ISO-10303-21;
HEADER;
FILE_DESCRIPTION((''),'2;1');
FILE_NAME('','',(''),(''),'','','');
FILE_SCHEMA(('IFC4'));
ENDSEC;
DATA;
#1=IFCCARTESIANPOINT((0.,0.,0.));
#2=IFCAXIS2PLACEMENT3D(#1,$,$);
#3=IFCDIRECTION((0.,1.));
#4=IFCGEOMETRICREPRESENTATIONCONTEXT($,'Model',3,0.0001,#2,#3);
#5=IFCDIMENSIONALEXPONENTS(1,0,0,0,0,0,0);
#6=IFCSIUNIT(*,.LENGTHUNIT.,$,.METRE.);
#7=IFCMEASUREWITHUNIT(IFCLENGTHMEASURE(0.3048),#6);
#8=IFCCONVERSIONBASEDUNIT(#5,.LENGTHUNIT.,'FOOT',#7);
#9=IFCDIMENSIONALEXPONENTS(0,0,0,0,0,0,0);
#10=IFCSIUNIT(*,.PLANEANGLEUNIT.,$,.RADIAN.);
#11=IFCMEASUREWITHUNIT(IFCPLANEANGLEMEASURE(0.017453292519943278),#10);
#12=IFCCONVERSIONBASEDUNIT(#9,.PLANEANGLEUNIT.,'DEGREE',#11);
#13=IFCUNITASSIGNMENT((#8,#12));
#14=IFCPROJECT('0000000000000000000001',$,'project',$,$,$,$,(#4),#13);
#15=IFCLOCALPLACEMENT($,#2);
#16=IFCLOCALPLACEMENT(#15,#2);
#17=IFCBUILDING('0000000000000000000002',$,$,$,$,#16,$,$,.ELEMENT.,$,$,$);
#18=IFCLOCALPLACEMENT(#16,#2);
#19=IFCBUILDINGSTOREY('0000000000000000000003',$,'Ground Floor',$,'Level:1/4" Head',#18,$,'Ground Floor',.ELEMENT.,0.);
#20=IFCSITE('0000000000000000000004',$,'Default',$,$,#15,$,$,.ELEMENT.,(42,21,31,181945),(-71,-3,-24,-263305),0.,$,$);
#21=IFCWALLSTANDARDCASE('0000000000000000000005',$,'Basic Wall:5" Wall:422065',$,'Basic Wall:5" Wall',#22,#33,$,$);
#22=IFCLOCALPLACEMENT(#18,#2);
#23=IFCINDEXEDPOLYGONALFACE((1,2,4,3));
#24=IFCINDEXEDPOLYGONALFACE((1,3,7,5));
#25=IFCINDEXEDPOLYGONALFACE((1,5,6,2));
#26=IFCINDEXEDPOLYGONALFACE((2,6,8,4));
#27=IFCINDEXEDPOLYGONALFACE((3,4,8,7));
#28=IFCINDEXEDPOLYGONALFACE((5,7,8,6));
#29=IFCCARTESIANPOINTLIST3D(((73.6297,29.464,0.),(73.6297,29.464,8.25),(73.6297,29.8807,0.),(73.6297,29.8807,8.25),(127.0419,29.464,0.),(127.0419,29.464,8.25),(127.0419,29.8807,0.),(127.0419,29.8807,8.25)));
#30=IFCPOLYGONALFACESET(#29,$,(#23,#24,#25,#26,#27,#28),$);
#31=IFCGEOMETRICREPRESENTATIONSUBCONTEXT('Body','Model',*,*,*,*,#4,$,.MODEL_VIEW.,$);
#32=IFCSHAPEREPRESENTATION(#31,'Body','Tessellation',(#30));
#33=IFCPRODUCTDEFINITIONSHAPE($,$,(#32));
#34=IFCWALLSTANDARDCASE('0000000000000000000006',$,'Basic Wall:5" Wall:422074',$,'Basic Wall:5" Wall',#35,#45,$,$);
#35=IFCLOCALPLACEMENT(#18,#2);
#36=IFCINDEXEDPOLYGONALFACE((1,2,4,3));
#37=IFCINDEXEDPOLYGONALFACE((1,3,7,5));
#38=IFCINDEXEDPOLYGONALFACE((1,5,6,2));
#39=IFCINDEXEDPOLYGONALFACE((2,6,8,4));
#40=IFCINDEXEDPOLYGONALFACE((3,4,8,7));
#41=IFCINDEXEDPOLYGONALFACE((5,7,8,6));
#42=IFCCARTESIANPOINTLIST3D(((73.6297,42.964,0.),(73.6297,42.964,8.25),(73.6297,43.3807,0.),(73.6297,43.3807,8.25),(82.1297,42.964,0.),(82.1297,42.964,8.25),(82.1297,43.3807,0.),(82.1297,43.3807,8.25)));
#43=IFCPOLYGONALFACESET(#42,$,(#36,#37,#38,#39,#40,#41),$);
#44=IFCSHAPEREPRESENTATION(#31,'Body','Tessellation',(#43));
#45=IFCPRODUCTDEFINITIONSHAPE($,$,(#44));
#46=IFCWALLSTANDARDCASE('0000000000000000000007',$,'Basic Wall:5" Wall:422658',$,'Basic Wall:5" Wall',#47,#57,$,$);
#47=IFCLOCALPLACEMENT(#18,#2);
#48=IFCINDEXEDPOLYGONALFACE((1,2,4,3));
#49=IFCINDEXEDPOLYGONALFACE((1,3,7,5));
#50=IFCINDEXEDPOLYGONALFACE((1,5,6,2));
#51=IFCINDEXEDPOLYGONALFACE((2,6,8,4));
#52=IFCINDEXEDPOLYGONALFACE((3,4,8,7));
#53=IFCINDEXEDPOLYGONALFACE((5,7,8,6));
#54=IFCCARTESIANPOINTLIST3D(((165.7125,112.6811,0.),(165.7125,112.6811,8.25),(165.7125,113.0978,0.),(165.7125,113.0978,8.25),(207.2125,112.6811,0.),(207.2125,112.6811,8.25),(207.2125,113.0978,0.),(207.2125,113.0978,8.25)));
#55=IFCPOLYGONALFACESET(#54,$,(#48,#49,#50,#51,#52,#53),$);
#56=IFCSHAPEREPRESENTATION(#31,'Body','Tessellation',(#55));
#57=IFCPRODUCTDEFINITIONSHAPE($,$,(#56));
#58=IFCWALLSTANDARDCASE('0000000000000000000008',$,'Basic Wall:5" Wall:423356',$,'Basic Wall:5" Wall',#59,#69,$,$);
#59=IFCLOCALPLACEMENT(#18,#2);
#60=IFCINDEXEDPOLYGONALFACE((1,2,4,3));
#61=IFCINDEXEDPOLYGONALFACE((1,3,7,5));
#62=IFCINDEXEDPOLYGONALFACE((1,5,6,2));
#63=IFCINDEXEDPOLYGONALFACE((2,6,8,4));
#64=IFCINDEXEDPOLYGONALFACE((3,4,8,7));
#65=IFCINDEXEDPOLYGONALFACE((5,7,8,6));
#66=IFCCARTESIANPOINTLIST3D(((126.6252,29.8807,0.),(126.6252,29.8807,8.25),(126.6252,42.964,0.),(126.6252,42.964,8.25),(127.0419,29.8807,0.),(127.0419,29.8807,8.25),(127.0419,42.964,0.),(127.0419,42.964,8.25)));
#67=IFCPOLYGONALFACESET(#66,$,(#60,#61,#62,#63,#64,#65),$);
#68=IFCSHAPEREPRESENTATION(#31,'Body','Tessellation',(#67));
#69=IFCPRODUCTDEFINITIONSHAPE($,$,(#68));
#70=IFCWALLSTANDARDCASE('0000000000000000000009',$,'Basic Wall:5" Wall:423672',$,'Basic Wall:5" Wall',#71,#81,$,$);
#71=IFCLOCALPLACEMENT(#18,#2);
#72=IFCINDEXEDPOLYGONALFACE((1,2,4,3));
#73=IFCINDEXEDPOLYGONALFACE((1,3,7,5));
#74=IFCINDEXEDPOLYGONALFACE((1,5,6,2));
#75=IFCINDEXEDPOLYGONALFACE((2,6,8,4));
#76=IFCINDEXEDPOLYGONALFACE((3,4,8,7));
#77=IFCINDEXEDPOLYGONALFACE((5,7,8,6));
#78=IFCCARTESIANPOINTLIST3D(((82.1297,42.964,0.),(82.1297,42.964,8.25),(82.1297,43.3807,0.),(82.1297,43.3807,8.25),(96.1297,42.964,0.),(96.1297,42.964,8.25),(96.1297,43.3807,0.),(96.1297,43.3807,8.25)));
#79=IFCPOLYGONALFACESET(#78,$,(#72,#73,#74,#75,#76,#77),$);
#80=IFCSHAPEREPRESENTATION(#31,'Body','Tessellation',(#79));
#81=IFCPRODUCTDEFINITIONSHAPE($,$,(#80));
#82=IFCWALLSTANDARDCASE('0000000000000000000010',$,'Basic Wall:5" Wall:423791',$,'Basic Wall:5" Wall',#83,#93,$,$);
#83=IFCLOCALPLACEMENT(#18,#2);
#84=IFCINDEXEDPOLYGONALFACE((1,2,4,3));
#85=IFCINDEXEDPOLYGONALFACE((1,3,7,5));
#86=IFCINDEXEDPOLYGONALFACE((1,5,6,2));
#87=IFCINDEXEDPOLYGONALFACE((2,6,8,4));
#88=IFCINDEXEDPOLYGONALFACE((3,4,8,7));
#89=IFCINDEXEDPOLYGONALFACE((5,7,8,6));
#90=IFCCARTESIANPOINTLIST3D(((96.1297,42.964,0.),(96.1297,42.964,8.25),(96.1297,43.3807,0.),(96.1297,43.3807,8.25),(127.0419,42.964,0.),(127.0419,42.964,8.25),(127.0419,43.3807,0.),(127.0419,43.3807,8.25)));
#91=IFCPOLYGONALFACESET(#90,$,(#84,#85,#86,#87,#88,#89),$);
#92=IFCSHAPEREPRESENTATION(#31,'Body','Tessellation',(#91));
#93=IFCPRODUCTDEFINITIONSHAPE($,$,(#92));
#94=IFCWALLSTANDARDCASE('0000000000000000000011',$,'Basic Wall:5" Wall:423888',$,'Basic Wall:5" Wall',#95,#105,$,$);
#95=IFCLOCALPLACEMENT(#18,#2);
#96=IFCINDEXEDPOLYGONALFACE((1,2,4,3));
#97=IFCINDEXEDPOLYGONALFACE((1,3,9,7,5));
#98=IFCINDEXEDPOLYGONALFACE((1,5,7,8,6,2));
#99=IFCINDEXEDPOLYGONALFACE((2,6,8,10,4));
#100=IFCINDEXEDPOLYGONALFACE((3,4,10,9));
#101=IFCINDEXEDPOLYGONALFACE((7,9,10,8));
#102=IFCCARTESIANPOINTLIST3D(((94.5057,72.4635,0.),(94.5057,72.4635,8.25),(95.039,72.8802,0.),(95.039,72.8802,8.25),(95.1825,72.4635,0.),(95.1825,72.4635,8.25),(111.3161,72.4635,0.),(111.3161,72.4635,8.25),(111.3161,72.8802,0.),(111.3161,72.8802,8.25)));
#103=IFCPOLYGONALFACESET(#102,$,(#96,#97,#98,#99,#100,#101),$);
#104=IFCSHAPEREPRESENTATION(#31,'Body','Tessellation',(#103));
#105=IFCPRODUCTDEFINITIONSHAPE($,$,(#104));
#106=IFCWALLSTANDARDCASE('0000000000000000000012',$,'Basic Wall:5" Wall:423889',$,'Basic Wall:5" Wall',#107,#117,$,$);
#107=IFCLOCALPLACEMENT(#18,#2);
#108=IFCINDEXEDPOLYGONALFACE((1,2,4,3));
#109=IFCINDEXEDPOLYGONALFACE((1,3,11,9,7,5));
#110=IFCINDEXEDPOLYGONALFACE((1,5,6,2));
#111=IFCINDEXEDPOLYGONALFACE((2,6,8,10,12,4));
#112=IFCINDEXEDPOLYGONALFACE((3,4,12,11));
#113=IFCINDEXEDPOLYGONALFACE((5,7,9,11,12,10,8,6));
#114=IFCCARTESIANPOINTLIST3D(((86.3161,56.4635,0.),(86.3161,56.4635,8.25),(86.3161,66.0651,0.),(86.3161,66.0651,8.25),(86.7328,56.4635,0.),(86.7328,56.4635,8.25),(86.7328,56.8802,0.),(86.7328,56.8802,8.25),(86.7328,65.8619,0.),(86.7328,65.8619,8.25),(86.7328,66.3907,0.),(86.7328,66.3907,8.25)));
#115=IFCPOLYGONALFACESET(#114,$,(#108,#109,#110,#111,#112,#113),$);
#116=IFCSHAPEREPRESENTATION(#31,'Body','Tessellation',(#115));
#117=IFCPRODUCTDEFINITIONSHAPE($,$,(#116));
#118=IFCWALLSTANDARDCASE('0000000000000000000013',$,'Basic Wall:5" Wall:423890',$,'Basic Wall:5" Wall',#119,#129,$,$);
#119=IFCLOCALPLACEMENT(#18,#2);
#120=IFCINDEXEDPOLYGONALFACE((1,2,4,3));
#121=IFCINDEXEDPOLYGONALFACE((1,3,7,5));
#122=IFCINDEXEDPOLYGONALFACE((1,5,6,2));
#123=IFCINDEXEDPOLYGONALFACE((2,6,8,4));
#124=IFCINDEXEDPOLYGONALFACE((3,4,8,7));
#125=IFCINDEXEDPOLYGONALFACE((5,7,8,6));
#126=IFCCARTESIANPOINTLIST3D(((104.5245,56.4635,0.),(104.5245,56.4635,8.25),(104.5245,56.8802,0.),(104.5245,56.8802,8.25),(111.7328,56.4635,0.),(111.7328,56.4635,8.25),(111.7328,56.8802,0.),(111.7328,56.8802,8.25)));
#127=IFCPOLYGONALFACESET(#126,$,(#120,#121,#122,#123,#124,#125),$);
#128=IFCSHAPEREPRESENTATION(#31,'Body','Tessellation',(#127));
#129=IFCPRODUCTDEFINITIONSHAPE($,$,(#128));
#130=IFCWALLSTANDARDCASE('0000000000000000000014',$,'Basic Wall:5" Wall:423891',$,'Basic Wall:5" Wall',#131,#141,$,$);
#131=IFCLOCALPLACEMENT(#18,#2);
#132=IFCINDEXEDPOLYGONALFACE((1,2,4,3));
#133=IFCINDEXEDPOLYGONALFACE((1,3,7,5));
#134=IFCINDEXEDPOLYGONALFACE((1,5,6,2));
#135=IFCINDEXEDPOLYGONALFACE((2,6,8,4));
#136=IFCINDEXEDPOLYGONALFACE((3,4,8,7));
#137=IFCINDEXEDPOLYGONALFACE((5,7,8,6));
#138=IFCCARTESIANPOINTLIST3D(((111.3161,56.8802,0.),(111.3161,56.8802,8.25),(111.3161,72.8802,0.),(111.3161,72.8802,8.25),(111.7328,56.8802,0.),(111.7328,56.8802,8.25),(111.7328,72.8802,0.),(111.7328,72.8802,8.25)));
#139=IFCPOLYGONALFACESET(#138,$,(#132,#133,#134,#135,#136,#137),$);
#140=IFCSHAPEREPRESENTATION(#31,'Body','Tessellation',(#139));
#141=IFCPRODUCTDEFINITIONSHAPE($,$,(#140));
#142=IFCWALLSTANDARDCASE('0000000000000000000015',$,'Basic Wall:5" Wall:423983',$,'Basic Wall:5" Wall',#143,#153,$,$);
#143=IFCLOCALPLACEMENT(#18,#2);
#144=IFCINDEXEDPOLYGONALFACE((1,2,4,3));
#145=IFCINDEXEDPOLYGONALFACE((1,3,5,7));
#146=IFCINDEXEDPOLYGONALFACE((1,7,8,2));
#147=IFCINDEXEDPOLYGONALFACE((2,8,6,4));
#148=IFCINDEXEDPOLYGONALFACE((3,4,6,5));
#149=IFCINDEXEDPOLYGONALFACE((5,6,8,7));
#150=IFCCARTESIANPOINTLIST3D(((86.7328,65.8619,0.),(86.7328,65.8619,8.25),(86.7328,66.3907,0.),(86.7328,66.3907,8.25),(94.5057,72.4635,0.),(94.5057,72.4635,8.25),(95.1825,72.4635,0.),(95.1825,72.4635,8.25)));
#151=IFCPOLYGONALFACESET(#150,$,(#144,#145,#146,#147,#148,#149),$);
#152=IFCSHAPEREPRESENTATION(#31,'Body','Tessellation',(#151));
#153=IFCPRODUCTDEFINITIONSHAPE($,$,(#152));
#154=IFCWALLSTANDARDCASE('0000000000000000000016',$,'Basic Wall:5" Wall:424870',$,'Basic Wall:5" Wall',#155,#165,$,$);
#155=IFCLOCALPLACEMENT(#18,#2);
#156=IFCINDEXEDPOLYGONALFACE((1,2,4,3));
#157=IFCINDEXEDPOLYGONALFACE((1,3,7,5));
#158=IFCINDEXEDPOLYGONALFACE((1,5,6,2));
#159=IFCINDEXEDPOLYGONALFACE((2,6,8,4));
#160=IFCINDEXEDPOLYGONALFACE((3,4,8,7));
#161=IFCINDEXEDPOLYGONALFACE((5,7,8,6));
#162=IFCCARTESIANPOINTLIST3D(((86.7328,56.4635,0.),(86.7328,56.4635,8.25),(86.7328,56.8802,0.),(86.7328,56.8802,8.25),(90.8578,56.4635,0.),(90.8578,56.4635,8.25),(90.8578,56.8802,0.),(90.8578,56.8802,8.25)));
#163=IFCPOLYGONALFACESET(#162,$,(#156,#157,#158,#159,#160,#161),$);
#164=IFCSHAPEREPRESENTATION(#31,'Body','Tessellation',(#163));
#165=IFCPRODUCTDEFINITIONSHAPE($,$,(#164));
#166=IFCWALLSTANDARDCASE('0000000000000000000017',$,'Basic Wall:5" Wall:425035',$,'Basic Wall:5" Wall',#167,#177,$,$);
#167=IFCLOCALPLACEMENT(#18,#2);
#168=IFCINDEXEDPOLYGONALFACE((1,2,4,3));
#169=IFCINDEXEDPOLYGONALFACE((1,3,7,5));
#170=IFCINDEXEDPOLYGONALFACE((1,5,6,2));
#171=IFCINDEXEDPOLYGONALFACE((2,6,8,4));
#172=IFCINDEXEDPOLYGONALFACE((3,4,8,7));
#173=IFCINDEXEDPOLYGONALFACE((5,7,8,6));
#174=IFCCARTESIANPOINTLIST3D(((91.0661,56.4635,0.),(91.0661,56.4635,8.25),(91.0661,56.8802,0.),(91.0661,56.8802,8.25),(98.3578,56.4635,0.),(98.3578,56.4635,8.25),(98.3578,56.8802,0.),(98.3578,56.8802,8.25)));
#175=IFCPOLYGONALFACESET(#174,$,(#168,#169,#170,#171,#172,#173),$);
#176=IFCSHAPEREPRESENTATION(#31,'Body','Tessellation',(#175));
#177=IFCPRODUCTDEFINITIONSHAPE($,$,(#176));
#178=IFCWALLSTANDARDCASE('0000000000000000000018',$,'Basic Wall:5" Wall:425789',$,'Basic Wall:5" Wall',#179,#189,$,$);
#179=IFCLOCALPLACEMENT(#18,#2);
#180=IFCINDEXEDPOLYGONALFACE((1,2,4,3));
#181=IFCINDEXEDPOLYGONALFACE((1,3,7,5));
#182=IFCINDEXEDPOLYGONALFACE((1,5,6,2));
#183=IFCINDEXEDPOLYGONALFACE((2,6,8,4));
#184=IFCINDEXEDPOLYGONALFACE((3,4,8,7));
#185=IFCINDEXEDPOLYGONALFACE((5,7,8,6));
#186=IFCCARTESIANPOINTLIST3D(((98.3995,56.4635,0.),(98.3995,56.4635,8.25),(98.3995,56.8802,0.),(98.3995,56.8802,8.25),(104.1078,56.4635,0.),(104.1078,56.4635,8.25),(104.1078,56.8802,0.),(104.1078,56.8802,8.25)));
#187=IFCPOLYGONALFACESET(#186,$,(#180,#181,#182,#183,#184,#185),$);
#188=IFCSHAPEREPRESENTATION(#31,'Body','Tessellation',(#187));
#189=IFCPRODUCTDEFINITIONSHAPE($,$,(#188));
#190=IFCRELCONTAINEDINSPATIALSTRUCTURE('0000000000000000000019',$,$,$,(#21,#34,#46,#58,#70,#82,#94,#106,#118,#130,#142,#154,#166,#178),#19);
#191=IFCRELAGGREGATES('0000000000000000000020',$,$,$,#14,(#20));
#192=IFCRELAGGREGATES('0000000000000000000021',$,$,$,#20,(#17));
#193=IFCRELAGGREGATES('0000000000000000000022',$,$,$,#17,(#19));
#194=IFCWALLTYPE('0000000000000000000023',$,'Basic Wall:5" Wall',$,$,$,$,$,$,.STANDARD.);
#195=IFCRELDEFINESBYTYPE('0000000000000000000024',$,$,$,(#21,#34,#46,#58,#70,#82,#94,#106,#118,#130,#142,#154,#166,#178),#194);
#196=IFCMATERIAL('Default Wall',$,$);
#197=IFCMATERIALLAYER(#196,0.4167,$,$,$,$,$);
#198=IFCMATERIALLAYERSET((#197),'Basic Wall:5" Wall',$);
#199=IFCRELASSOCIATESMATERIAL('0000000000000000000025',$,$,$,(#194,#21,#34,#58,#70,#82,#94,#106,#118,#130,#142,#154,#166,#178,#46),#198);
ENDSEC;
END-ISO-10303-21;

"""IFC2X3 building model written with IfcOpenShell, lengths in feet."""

from ifc_helpers import new_model, entity, si_unit, converted_unit, direction, frame, frame_2d, origin, place, context, subcontext, project, spatial, polyline, rectangle, outline, extrude, material, layer, layer_set, layer_usage, type_object, element, save


model = new_model("IFC2X3")

# Units and contexts
model_context = context("Model", 3, precision=0.0001, world=origin(), true_north=direction((0.0, 1.0)))
body_context = subcontext(model_context, "Body", "Model", "MODEL_VIEW")
ifc_project = project(units=[converted_unit("LENGTHUNIT", "FOOT", entity("IfcLengthMeasure", 0.3048), si_unit("LENGTHUNIT", "METRE"), dimensions=[1, 0, 0, 0, 0, 0, 0]), converted_unit("PLANEANGLEUNIT", "DEGREE", entity("IfcPlaneAngleMeasure", 0.017453292519943278), si_unit("PLANEANGLEUNIT", "RADIAN"), dimensions=[0, 0, 0, 0, 0, 0, 0])], contexts=[model_context])

# Site, building, storey
site_placement = place(None, origin())
site = spatial("IfcSite", under=ifc_project, at=site_placement, Name="Default", CompositionType="ELEMENT", RefLatitude=(42, 21, 31, 181945), RefLongitude=(-71, -3, -24, -263305), RefElevation=0.0)
building_placement = place(site_placement, origin())
building = spatial("IfcBuilding", under=site, at=building_placement, CompositionType="ELEMENT")
storey_placement = place(building_placement, origin())
storey = spatial("IfcBuildingStorey", under=building, at=storey_placement, Name="Ground Floor", ObjectType="Level:1/4\" Head", LongName="Ground Floor", CompositionType="ELEMENT", Elevation=0.0)

# Walls
ifc_material = material(Name="Default Wall")
ifc_layer = layer(ifc_material, 0.4167)
ifc_layer_set = layer_set([ifc_layer], Name="Basic Wall:5\" Wall")
ifc_layer_usage_1 = layer_usage(ifc_layer_set, "AXIS2", "NEGATIVE", 0.2083)
wall_type = type_object("IfcWallType", Name="Basic Wall:5\" Wall", PredefinedType="STANDARD", material=ifc_layer_set)
wall_1_placement = place(storey_placement, frame((73.6297, 29.6723, 0.0)))
element("IfcWallStandardCase", 1, at=wall_1_placement, inside=storey, type_object=wall_type, material=ifc_layer_usage_1, Name="Basic Wall:5\" Wall:422065", ObjectType="Basic Wall:5\" Wall", context=body_context, shape_type="SweptSolid", body=[
    extrude(rectangle(XDim=53.4122, YDim=0.4167, at=frame_2d((26.7061, 0.0), x_axis=(-1.0, 0.0))), origin(), (0.0, 0.0, 1.0), 8.25),
])
wall_2_placement = place(storey_placement, frame((73.6297, 43.1723, 0.0)))
element("IfcWallStandardCase", 2, at=wall_2_placement, inside=storey, type_object=wall_type, material=ifc_layer_usage_1, Name="Basic Wall:5\" Wall:422074", ObjectType="Basic Wall:5\" Wall", context=body_context, shape_type="SweptSolid", body=[
    extrude(rectangle(XDim=8.5, YDim=0.4167, at=frame_2d((4.25, 0.0), x_axis=(-1.0, 0.0))), origin(), (0.0, 0.0, 1.0), 8.25),
])
ifc_layer_usage_2 = layer_usage(ifc_layer_set, "AXIS2", "POSITIVE", -0.2083)
wall_3_placement = place(storey_placement, frame((207.2125, 112.8894, 0.0), z_axis=(0.0, 0.0, 1.0), x_axis=(-1.0, 0.0, 0.0)))
element("IfcWallStandardCase", 3, at=wall_3_placement, inside=storey, type_object=wall_type, material=ifc_layer_usage_2, Name="Basic Wall:5\" Wall:422658", ObjectType="Basic Wall:5\" Wall", context=body_context, shape_type="SweptSolid", body=[
    extrude(rectangle(XDim=41.5, YDim=0.4167, at=frame_2d((20.75, 0.0), x_axis=(-1.0, 0.0))), origin(), (0.0, 0.0, 1.0), 8.25),
])
wall_4_placement = place(storey_placement, frame((126.8335, 42.964, 0.0), z_axis=(0.0, 0.0, 1.0), x_axis=(0.0, -1.0, 0.0)))
element("IfcWallStandardCase", 4, at=wall_4_placement, inside=storey, type_object=wall_type, material=ifc_layer_usage_1, Name="Basic Wall:5\" Wall:423356", ObjectType="Basic Wall:5\" Wall", context=body_context, shape_type="SweptSolid", body=[
    extrude(rectangle(XDim=13.0833, YDim=0.4167, at=frame_2d((6.5417, 0.0), x_axis=(-1.0, 0.0))), origin(), (0.0, 0.0, 1.0), 8.25),
])
wall_5_placement = place(storey_placement, frame((82.1297, 43.1723, 0.0)))
element("IfcWallStandardCase", 5, at=wall_5_placement, inside=storey, type_object=wall_type, material=ifc_layer_usage_1, Name="Basic Wall:5\" Wall:423672", ObjectType="Basic Wall:5\" Wall", context=body_context, shape_type="SweptSolid", body=[
    extrude(rectangle(XDim=14.0, YDim=0.4167, at=frame_2d((7.0, 0.0), x_axis=(-1.0, 0.0))), origin(), (0.0, 0.0, 1.0), 8.25),
])
wall_6_placement = place(storey_placement, frame((96.1297, 43.1723, 0.0)))
element("IfcWallStandardCase", 6, at=wall_6_placement, inside=storey, type_object=wall_type, material=ifc_layer_usage_1, Name="Basic Wall:5\" Wall:423791", ObjectType="Basic Wall:5\" Wall", context=body_context, shape_type="SweptSolid", body=[
    extrude(rectangle(XDim=30.9122, YDim=0.4167, at=frame_2d((15.4561, 0.0), x_axis=(-1.0, 0.0))), origin(), (0.0, 0.0, 1.0), 8.25),
])
wall_7_placement = place(storey_placement, frame((94.5057, 72.6718, 0.0)))
element("IfcWallStandardCase", 7, at=wall_7_placement, inside=storey, type_object=wall_type, material=ifc_layer_usage_1, Name="Basic Wall:5\" Wall:423888", ObjectType="Basic Wall:5\" Wall", context=body_context, shape_type="SweptSolid", body=[
    extrude(outline(polyline([(16.8104, -0.2083), (16.8104, 0.2083), (0.5333, 0.2083), (0.0, -0.2083), (0.6768, -0.2083), (16.8104, -0.2083)])), origin(), (0.0, 0.0, 1.0), 8.25),
])
wall_8_placement = place(storey_placement, frame((86.5245, 56.4635, 0.0), z_axis=(0.0, 0.0, 1.0), x_axis=(0.0, 1.0, 0.0)))
element("IfcWallStandardCase", 8, at=wall_8_placement, inside=storey, type_object=wall_type, material=ifc_layer_usage_1, Name="Basic Wall:5\" Wall:423889", ObjectType="Basic Wall:5\" Wall", context=body_context, shape_type="SweptSolid", body=[
    extrude(outline(polyline([(9.9271, -0.2083), (9.6016, 0.2083), (0.0, 0.2083), (0.0, -0.2083), (0.4167, -0.2083), (9.3984, -0.2083), (9.9271, -0.2083)])), origin(), (0.0, 0.0, 1.0), 8.25),
])
wall_9_placement = place(storey_placement, frame((111.7328, 56.6718, 0.0), z_axis=(0.0, 0.0, 1.0), x_axis=(-1.0, 0.0, 0.0)))
element("IfcWallStandardCase", 9, at=wall_9_placement, inside=storey, type_object=wall_type, material=ifc_layer_usage_1, Name="Basic Wall:5\" Wall:423890", ObjectType="Basic Wall:5\" Wall", context=body_context, shape_type="SweptSolid", body=[
    extrude(rectangle(XDim=7.2083, YDim=0.4167, at=frame_2d((3.6042, 0.0), x_axis=(-1.0, 0.0))), origin(), (0.0, 0.0, 1.0), 8.25),
])
wall_10_placement = place(storey_placement, frame((111.5245, 72.8802, 0.0), z_axis=(0.0, 0.0, 1.0), x_axis=(0.0, -1.0, 0.0)))
element("IfcWallStandardCase", 10, at=wall_10_placement, inside=storey, type_object=wall_type, material=ifc_layer_usage_1, Name="Basic Wall:5\" Wall:423891", ObjectType="Basic Wall:5\" Wall", context=body_context, shape_type="SweptSolid", body=[
    extrude(rectangle(XDim=16.0, YDim=0.4167, at=frame_2d((8.0, 0.0), x_axis=(-1.0, 0.0))), origin(), (0.0, 0.0, 1.0), 8.25),
])
wall_11_placement = place(storey_placement, frame((86.6045, 66.0261, 0.0), z_axis=(0.0, 0.0, 1.0), x_axis=(0.788011, 0.615661, 0.0)))
element("IfcWallStandardCase", 11, at=wall_11_placement, inside=storey, type_object=wall_type, material=ifc_layer_usage_1, Name="Basic Wall:5\" Wall:423983", ObjectType="Basic Wall:5\" Wall", context=body_context, shape_type="SweptSolid", body=[
    extrude(outline(polyline([(10.7228, -0.2083), (10.1895, 0.2083), (0.3255, 0.2083), (0.0, -0.2083), (10.7228, -0.2083)])), origin(), (0.0, 0.0, 1.0), 8.25),
])
wall_12_placement = place(storey_placement, frame((90.8578, 56.6718, 0.0), z_axis=(0.0, 0.0, 1.0), x_axis=(-1.0, 0.0, 0.0)))
element("IfcWallStandardCase", 12, at=wall_12_placement, inside=storey, type_object=wall_type, material=ifc_layer_usage_1, Name="Basic Wall:5\" Wall:424870", ObjectType="Basic Wall:5\" Wall", context=body_context, shape_type="SweptSolid", body=[
    extrude(rectangle(XDim=4.125, YDim=0.4167, at=frame_2d((2.0625, 0.0), x_axis=(-1.0, 0.0))), origin(), (0.0, 0.0, 1.0), 8.25),
])
wall_13_placement = place(storey_placement, frame((98.3578, 56.6718, 0.0), z_axis=(0.0, 0.0, 1.0), x_axis=(-1.0, 0.0, 0.0)))
element("IfcWallStandardCase", 13, at=wall_13_placement, inside=storey, type_object=wall_type, material=ifc_layer_usage_1, Name="Basic Wall:5\" Wall:425035", ObjectType="Basic Wall:5\" Wall", context=body_context, shape_type="SweptSolid", body=[
    extrude(rectangle(XDim=7.2917, YDim=0.4167, at=frame_2d((3.6458, 0.0), x_axis=(-1.0, 0.0))), origin(), (0.0, 0.0, 1.0), 8.25),
])
wall_14_placement = place(storey_placement, frame((104.1078, 56.6718, 0.0), z_axis=(0.0, 0.0, 1.0), x_axis=(-1.0, 0.0, 0.0)))
element("IfcWallStandardCase", 14, at=wall_14_placement, inside=storey, type_object=wall_type, material=ifc_layer_usage_1, Name="Basic Wall:5\" Wall:425789", ObjectType="Basic Wall:5\" Wall", context=body_context, shape_type="SweptSolid", body=[
    extrude(rectangle(XDim=5.7083, YDim=0.4167, at=frame_2d((2.8542, 0.0), x_axis=(-1.0, 0.0))), origin(), (0.0, 0.0, 1.0), 8.25),
])

save(model, "model.ifc")
